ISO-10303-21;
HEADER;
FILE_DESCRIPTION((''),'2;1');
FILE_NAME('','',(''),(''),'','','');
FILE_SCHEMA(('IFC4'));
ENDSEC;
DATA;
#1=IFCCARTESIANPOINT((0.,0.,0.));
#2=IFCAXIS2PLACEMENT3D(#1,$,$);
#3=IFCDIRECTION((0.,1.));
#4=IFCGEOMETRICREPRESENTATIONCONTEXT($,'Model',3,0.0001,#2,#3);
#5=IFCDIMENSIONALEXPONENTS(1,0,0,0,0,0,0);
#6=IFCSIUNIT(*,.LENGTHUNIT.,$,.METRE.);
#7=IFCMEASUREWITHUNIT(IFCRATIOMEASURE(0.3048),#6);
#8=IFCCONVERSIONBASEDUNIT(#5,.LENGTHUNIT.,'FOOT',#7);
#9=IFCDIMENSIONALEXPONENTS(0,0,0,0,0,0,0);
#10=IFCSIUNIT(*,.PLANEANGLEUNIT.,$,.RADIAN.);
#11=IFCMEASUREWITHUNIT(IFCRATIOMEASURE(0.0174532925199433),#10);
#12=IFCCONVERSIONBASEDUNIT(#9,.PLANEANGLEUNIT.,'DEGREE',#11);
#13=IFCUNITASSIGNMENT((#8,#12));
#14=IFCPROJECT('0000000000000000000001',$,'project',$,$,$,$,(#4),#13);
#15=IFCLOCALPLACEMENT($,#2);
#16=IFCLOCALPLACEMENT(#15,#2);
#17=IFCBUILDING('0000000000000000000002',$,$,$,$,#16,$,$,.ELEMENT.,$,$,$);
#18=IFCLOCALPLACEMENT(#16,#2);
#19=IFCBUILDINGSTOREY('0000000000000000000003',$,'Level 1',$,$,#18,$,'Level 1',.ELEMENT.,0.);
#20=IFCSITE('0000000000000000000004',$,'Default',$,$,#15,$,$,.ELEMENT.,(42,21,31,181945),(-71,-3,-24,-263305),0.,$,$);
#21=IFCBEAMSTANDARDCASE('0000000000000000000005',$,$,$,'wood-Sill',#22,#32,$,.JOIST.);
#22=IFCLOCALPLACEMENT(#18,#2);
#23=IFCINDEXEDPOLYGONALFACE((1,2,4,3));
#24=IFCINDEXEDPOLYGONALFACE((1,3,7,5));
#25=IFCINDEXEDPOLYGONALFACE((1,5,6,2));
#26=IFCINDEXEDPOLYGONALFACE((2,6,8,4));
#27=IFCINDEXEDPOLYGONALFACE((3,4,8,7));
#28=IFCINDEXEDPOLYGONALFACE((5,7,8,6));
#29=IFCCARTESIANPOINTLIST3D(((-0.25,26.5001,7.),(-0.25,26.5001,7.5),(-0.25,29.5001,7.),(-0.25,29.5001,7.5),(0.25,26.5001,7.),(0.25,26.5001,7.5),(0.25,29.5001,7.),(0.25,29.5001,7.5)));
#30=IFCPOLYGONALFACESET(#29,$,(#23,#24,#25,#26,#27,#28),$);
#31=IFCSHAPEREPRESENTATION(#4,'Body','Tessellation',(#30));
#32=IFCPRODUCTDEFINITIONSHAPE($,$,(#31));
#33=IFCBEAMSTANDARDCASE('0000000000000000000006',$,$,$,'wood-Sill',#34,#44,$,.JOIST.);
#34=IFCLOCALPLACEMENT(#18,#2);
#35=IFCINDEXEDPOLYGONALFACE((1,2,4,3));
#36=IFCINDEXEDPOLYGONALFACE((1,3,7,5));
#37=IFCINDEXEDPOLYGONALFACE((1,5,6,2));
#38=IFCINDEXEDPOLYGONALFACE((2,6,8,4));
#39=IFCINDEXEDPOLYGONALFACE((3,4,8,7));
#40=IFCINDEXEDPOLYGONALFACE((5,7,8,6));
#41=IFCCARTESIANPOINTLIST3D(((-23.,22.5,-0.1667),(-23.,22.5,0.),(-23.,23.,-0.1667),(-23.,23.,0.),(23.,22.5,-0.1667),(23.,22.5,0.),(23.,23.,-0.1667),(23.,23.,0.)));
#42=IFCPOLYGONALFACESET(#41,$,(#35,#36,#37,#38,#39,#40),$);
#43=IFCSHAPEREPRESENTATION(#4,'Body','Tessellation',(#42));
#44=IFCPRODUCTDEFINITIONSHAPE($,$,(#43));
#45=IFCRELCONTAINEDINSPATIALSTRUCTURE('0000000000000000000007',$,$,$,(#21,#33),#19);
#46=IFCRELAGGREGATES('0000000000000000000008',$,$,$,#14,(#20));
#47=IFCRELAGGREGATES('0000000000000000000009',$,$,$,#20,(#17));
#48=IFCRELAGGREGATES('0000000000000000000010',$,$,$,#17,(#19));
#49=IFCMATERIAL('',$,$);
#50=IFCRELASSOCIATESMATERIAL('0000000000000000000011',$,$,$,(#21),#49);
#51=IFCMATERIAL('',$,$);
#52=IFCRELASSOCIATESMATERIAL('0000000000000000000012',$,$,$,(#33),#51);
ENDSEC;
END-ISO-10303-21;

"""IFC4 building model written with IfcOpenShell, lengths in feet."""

from ifc_helpers import new_model, entity, si_unit, converted_unit, direction, frame, origin, place, context, project, spatial, rectangle, extrude, material, element, save


model = new_model("IFC4")

# Units and contexts
model_context = context("Model", 3, precision=0.0001, world=origin(), true_north=direction((0.0, 1.0)))
ifc_project = project(units=[converted_unit("LENGTHUNIT", "FOOT", entity("IfcRatioMeasure", 0.3048), si_unit("LENGTHUNIT", "METRE"), dimensions=[1, 0, 0, 0, 0, 0, 0]), converted_unit("PLANEANGLEUNIT", "DEGREE", entity("IfcRatioMeasure", 0.0174532925199433), si_unit("PLANEANGLEUNIT", "RADIAN"), dimensions=[0, 0, 0, 0, 0, 0, 0])], contexts=[model_context])

# Site, building, storey
site_placement = place(None, origin())
site = spatial("IfcSite", under=ifc_project, at=site_placement, Name="Default", CompositionType="ELEMENT", RefLatitude=(42, 21, 31, 181945), RefLongitude=(-71, -3, -24, -263305), RefElevation=0.0)
building_placement = place(site_placement, origin())
building = spatial("IfcBuilding", under=site, at=building_placement, CompositionType="ELEMENT")
storey_placement = place(building_placement, origin())
storey = spatial("IfcBuildingStorey", under=building, at=storey_placement, Name="Level 1", LongName="Level 1", CompositionType="ELEMENT", Elevation=0.0)

# Shared definitions
placement = place(storey_placement, frame((0.0, -0.25, 0.0), z_axis=(0.0, 0.0, 1.0), x_axis=(0.0, 1.0, 0.0)))

# Beams
ifc_material_1 = material(Name="")
for number, where, z_axis, x_axis in (
    (1, (28.2501, 0.0, 7.0), (0.0, 0.0, 1.0), (-1.0, 0.0, 0.0)),
):
    element("IfcBeamStandardCase", number, at=place(placement, frame(where, z_axis=z_axis, x_axis=x_axis)), inside=storey, material=ifc_material_1, ObjectType="wood-Sill", PredefinedType="JOIST", context=model_context, shape_type="SweptSolid", body=[
        extrude(rectangle(XDim=3.0, YDim=0.5), origin(), (0.0, 0.0, 1.0), 0.5),
    ])
ifc_material_2 = material(Name="")
beam_1_placement = place(placement, frame((23.0, 0.0, -0.1667), z_axis=(0.0, 0.0, 1.0), x_axis=(0.0, 1.0, 0.0)))
element("IfcBeamStandardCase", 2, at=beam_1_placement, inside=storey, material=ifc_material_2, ObjectType="wood-Sill", PredefinedType="JOIST", context=model_context, shape_type="SweptSolid", body=[
    extrude(rectangle(XDim=46.0, YDim=0.5), origin(), (0.0, 0.0, 1.0), 0.1667),
])

save(model, "model.ifc")
